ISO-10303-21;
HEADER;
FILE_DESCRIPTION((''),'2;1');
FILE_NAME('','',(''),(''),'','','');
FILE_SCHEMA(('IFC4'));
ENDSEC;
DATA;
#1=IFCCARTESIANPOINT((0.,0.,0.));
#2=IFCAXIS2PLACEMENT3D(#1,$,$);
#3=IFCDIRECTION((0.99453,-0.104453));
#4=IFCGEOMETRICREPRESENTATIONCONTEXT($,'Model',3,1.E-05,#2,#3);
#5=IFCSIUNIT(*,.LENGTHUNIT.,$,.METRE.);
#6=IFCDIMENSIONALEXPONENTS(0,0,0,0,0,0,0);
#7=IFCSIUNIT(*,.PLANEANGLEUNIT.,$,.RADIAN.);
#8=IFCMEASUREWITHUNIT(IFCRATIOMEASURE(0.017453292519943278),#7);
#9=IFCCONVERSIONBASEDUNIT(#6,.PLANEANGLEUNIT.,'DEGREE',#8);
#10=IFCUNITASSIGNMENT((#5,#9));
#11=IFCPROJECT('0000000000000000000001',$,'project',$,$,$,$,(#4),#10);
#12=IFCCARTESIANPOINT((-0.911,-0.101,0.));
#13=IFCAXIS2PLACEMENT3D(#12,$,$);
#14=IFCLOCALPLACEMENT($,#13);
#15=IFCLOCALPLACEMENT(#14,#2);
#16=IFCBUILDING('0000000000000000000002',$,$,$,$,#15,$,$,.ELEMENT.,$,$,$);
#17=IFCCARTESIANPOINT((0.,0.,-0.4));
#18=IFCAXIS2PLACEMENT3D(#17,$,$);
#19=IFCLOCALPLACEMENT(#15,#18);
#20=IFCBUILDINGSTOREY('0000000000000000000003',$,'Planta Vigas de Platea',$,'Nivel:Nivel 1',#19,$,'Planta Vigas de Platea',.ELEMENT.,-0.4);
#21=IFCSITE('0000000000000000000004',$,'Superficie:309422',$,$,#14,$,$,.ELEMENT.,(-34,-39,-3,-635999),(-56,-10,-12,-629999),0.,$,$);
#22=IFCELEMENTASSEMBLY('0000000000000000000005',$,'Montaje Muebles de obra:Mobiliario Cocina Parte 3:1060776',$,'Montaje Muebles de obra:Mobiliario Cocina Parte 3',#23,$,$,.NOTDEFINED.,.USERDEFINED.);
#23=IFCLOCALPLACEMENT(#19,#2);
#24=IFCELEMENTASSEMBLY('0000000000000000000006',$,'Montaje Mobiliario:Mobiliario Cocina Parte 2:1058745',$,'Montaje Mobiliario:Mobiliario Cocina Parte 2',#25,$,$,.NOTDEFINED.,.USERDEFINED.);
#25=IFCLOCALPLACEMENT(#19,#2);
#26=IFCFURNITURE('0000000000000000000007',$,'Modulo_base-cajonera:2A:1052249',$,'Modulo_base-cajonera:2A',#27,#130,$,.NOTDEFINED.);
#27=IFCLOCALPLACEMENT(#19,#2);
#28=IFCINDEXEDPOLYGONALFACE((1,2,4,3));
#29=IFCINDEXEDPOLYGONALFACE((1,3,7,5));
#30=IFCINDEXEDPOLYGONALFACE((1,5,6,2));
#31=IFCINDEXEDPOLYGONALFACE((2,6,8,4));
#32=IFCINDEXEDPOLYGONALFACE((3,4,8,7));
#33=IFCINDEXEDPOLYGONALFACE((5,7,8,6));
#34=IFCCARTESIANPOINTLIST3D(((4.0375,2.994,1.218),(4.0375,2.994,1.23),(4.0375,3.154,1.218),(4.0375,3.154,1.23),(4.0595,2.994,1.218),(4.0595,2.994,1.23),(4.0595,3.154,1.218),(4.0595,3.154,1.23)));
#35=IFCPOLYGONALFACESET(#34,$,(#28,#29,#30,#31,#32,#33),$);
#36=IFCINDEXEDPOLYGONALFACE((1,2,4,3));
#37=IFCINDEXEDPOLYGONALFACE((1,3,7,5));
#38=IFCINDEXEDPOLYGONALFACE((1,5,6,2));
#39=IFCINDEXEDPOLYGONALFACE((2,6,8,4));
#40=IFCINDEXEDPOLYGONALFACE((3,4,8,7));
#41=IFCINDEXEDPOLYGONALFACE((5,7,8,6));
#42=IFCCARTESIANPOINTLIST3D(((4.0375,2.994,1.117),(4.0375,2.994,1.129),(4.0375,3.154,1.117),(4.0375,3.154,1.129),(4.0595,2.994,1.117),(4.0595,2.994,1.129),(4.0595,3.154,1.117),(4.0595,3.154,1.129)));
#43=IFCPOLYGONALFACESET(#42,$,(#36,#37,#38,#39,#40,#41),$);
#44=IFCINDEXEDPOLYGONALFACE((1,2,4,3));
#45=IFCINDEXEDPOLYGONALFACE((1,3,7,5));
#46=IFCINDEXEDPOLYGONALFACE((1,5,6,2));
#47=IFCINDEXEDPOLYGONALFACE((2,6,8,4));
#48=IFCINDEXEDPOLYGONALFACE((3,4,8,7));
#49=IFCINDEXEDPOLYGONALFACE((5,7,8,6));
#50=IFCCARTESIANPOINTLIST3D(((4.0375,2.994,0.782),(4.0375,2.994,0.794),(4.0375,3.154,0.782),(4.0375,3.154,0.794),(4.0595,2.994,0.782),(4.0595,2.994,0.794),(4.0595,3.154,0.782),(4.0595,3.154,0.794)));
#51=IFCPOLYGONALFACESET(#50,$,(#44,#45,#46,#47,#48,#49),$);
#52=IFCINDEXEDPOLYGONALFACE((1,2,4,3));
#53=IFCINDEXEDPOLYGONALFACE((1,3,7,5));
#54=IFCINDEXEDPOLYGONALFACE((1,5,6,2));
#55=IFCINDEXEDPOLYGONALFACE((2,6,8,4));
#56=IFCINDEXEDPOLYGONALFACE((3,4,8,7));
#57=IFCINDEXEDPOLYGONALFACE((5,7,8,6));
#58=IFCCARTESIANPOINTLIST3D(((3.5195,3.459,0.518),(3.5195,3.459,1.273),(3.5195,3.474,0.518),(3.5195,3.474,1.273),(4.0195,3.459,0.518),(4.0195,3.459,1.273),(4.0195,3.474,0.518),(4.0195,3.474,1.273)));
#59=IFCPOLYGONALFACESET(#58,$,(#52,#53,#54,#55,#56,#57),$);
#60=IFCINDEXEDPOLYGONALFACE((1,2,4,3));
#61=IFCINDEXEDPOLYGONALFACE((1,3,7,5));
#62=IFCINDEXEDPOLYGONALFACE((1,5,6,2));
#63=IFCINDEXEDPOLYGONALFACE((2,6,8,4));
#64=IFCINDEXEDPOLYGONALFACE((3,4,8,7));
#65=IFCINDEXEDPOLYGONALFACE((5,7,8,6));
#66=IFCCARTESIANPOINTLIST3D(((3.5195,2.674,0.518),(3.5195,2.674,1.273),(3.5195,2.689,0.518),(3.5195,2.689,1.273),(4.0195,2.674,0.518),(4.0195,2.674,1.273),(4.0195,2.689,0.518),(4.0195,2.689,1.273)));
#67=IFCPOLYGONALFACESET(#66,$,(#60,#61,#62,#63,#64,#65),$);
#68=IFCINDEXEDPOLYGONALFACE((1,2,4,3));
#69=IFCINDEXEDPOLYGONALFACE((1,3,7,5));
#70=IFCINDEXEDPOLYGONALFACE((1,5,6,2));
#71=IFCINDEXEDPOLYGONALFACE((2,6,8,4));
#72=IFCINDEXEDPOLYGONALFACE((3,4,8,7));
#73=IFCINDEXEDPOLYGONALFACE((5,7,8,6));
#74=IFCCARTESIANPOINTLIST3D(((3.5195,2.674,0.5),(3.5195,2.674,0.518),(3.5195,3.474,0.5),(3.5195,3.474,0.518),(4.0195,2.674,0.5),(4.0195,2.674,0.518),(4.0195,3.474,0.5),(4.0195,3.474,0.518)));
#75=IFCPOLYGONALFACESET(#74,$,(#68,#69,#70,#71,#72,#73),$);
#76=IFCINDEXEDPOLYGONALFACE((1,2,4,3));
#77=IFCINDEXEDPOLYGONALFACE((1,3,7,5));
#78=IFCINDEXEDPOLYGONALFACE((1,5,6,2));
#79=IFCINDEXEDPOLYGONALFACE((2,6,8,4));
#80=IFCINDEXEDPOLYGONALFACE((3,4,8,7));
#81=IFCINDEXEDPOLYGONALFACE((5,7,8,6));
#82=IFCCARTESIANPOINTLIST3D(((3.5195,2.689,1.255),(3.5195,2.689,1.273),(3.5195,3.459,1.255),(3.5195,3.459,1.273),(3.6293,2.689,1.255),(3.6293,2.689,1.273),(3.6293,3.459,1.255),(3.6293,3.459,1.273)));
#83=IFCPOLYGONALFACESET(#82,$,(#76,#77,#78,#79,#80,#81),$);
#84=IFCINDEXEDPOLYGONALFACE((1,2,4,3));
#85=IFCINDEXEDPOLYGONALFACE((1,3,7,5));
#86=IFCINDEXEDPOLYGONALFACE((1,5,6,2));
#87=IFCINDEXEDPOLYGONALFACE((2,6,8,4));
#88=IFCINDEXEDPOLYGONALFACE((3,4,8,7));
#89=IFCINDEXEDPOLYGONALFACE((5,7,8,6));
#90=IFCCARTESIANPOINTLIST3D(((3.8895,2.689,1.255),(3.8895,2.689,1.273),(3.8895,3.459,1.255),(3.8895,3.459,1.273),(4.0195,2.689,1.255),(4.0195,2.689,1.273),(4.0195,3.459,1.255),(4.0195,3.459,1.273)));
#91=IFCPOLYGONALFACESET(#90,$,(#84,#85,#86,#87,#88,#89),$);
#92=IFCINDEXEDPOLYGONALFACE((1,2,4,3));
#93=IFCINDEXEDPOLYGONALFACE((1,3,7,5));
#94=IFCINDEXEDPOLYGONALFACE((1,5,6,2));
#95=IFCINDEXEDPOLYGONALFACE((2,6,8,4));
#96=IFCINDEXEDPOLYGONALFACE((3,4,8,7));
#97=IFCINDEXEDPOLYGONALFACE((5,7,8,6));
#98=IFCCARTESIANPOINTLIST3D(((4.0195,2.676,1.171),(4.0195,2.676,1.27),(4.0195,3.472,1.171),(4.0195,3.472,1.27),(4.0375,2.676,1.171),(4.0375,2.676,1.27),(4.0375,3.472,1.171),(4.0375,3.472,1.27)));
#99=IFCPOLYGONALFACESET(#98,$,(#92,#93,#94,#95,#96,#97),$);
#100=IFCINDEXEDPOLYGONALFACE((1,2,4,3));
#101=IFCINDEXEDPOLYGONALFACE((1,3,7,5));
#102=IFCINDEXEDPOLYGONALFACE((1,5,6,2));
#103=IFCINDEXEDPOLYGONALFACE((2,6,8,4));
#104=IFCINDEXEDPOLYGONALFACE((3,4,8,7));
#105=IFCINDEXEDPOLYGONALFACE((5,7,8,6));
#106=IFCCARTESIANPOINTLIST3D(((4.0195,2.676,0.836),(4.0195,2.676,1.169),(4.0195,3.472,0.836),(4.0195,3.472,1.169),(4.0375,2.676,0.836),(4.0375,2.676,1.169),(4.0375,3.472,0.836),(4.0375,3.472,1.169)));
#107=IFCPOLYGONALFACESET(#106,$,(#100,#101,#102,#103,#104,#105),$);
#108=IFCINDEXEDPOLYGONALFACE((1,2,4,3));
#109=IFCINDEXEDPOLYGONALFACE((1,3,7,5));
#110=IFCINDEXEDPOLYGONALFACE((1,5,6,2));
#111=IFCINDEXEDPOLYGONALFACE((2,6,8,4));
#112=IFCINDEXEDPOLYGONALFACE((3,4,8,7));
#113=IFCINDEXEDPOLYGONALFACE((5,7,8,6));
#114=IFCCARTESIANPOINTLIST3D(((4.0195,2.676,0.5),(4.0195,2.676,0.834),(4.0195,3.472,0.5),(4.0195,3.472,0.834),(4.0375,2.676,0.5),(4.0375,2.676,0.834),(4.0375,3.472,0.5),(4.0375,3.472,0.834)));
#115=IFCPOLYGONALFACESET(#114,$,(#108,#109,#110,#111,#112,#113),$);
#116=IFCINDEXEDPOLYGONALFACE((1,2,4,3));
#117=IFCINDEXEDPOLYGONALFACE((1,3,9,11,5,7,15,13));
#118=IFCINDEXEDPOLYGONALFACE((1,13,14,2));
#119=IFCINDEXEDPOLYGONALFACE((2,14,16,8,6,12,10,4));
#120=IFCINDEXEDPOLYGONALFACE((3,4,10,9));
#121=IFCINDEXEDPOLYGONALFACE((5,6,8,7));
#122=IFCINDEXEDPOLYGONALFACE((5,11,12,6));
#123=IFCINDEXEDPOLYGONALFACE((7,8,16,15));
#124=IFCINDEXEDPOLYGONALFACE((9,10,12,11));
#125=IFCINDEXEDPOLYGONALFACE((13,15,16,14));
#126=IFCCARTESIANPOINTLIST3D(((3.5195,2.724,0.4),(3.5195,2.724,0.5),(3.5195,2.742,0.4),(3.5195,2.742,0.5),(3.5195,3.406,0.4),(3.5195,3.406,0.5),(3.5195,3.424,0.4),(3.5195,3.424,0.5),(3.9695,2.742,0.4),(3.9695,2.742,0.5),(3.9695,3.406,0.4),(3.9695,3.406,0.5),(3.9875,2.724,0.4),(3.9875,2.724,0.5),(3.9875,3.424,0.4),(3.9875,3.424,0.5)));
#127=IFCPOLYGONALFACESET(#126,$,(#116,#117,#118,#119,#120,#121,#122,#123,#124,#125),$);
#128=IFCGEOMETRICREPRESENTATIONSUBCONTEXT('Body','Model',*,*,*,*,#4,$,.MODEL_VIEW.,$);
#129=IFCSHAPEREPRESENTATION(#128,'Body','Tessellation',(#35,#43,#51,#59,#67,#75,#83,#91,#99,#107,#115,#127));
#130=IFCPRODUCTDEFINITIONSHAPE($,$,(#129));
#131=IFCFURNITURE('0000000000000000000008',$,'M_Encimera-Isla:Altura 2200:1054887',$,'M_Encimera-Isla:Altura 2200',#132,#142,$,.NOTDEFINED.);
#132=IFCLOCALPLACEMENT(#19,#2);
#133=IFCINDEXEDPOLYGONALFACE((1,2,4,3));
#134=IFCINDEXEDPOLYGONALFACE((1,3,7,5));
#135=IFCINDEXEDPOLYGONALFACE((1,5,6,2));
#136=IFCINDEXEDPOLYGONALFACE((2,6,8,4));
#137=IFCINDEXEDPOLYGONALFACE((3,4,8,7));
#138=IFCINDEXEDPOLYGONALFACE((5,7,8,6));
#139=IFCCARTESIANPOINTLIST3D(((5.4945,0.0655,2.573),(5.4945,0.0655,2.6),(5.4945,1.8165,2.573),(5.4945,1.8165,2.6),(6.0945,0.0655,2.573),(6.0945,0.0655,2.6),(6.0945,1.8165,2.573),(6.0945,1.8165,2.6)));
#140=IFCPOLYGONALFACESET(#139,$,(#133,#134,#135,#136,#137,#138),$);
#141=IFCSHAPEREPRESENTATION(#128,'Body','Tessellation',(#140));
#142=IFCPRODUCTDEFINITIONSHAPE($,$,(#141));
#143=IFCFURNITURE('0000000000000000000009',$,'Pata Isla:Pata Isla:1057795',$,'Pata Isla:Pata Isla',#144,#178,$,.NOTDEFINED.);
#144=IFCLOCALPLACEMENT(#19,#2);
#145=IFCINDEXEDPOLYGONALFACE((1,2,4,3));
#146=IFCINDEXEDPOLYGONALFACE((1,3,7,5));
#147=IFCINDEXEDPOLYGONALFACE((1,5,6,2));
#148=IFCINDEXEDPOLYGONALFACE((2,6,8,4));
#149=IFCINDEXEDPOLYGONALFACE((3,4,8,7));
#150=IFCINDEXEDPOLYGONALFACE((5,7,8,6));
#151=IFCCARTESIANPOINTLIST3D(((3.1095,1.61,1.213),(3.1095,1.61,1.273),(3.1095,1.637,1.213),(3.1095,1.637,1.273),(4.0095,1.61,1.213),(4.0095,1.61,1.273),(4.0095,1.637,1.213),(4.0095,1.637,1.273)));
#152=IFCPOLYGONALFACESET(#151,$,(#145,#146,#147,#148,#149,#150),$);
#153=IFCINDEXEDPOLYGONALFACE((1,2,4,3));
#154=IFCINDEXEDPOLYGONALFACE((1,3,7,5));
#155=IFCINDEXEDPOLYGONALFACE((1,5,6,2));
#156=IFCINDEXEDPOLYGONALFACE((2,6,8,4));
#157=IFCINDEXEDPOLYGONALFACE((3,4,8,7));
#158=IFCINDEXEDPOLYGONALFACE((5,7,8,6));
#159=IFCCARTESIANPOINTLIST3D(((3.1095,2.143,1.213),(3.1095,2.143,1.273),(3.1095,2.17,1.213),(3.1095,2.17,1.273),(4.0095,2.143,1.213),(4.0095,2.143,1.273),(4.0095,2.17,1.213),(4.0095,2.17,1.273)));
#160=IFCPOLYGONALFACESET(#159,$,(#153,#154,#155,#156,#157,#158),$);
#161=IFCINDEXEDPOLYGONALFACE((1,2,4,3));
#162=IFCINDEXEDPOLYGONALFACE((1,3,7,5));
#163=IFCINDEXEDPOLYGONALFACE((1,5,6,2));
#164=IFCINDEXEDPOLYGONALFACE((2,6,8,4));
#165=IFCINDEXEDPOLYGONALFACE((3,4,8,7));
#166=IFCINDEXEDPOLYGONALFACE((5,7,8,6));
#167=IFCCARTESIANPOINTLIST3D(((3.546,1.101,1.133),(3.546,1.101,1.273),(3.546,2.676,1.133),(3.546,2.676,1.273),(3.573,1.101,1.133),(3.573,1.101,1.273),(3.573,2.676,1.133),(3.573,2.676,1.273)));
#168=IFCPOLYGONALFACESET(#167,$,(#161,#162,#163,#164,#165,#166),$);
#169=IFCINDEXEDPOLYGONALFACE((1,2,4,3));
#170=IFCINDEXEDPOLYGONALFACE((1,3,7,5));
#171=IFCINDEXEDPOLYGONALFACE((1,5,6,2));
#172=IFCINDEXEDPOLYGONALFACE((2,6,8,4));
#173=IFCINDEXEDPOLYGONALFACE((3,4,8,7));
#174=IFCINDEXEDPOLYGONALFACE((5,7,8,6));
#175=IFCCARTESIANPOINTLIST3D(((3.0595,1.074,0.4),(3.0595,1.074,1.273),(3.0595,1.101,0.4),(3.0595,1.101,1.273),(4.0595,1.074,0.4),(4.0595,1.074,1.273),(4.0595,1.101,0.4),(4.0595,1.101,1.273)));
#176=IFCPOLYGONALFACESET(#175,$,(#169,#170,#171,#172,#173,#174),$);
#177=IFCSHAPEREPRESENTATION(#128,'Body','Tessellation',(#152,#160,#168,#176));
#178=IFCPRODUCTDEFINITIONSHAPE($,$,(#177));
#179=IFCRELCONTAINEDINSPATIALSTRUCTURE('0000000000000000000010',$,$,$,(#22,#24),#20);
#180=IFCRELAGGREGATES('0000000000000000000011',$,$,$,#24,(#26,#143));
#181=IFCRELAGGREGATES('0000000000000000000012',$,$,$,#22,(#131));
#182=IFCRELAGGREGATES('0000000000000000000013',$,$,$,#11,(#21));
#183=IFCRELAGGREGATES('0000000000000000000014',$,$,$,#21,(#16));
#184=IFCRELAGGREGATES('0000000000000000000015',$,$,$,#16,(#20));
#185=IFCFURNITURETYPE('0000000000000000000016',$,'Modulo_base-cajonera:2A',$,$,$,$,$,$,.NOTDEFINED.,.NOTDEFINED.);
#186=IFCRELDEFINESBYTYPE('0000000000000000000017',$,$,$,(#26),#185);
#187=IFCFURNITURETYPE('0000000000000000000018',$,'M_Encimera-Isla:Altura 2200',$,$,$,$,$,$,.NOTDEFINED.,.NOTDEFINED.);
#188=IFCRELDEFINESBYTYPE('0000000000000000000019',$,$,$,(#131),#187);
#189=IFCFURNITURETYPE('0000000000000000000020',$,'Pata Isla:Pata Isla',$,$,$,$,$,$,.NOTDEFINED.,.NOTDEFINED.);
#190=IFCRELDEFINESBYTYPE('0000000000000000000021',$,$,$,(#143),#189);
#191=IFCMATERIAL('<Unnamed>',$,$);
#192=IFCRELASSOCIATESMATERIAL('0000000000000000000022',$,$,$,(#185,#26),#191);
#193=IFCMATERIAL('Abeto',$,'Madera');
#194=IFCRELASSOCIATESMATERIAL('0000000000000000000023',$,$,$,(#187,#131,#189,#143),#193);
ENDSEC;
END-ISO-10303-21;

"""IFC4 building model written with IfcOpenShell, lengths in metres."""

from ifc_helpers import new_model, entity, si_unit, converted_unit, direction, frame, frame_2d, origin, origin_2d_with_axis, place, context, subcontext, project, spatial, polyline, rectangle, outline, extrude, source, transform, mapped, material, type_object, type_shapes, element, aggregate, save


model = new_model("IFC4")

# Units and contexts
model_context = context("Model", 3, precision=1e-05, world=origin(), true_north=direction((0.99453, -0.104453)))
body_context = subcontext(model_context, "Body", "Model", "MODEL_VIEW")
ifc_project = project(units=[si_unit("LENGTHUNIT", "METRE"), converted_unit("PLANEANGLEUNIT", "DEGREE", entity("IfcRatioMeasure", 0.017453292519943278), si_unit("PLANEANGLEUNIT", "RADIAN"), dimensions=[0, 0, 0, 0, 0, 0, 0])], contexts=[model_context])

# Site, building, storey
site_placement = place(None, frame((-0.911, -0.101, 0.0)))
site = spatial("IfcSite", under=ifc_project, at=site_placement, Name="Superficie:309422", CompositionType="ELEMENT", RefLatitude=(-34, -39, -3, -635999), RefLongitude=(-56, -10, -12, -629999), RefElevation=0.0)
building_placement = place(site_placement, origin())
building = spatial("IfcBuilding", under=site, at=building_placement, CompositionType="ELEMENT")
storey_placement = place(building_placement, frame((0.0, 0.0, -0.4)))
storey = spatial("IfcBuildingStorey", under=building, at=storey_placement, Name="Planta Vigas de Platea", ObjectType="Nivel:Nivel 1", LongName="Planta Vigas de Platea", CompositionType="ELEMENT", Elevation=-0.4)

# Element assemblies
ifc_material_1 = material(Name="Abeto", Category="Madera")
ifc_material_2 = material(Name="<Unnamed>")
assembly_1_placement = place(storey_placement, origin())
assembly_1 = element("IfcElementAssembly", 1, at=assembly_1_placement, inside=storey, Name="Montaje Muebles de obra:Mobiliario Cocina Parte 3:1060776", ObjectType="Montaje Muebles de obra:Mobiliario Cocina Parte 3", AssemblyPlace="NOTDEFINED", PredefinedType="USERDEFINED")
assembly_2_placement = place(storey_placement, origin())
assembly_2 = element("IfcElementAssembly", 2, at=assembly_2_placement, inside=storey, Name="Montaje Mobiliario:Mobiliario Cocina Parte 2:1058745", ObjectType="Montaje Mobiliario:Mobiliario Cocina Parte 2", AssemblyPlace="NOTDEFINED", PredefinedType="USERDEFINED")

# Furniture
furniture_type_1 = type_object("IfcFurnitureType", Name="Modulo_base-cajonera:2A", AssemblyPlace="NOTDEFINED", PredefinedType="NOTDEFINED", material=ifc_material_2)
shared_shape_1 = source(origin(), body_context, "Body", "SweptSolid", [
    extrude(rectangle(XDim=0.16, YDim=0.022, at=frame_2d((0.0, 0.0), x_axis=(1.0, 0.0))), frame((0.529, 0.4, 0.818), z_axis=(0.0, 0.0, 1.0), x_axis=(0.0, 1.0, 0.0)), (0.0, 0.0, 1.0), 0.012),
    extrude(rectangle(XDim=0.16, YDim=0.022, at=frame_2d((0.0, 0.0), x_axis=(1.0, 0.0))), frame((0.529, 0.4, 0.717), z_axis=(0.0, 0.0, 1.0), x_axis=(0.0, 1.0, 0.0)), (0.0, 0.0, 1.0), 0.012),
    extrude(rectangle(XDim=0.16, YDim=0.022, at=frame_2d((0.0, 0.0), x_axis=(1.0, 0.0))), frame((0.529, 0.4, 0.382), z_axis=(0.0, 0.0, 1.0), x_axis=(0.0, 1.0, 0.0)), (0.0, 0.0, 1.0), 0.012),
    extrude(rectangle(XDim=0.5, YDim=0.015, at=origin_2d_with_axis()), frame((0.25, 0.7925, 0.118), z_axis=(0.0, 0.0, 1.0), x_axis=(-1.0, 0.0, 0.0)), (0.0, 0.0, 1.0), 0.755),
    extrude(rectangle(XDim=0.5, YDim=0.015, at=frame_2d((0.0, 0.0), x_axis=(1.0, 0.0))), frame((0.25, 0.0075, 0.118), z_axis=(0.0, 0.0, 1.0), x_axis=(-1.0, 0.0, 0.0)), (0.0, 0.0, 1.0), 0.755),
    extrude(rectangle(XDim=0.5, YDim=0.8, at=frame_2d((0.0, 0.0), x_axis=(1.0, 0.0))), frame((0.25, 0.4, 0.1), z_axis=(0.0, 0.0, 1.0), x_axis=(-1.0, 0.0, 0.0)), (0.0, 0.0, 1.0), 0.018),
    extrude(rectangle(XDim=0.1098, YDim=0.77, at=frame_2d((0.0, 0.0), x_axis=(1.0, 0.0))), frame((0.0549, 0.4, 0.855), z_axis=(0.0, 0.0, 1.0), x_axis=(-1.0, 0.0, 0.0)), (0.0, 0.0, 1.0), 0.018),
    extrude(rectangle(XDim=0.13, YDim=0.77, at=frame_2d((0.0, 0.0), x_axis=(1.0, 0.0))), frame((0.435, 0.4, 0.855)), (0.0, 0.0, 1.0), 0.018),
    extrude(rectangle(XDim=0.796, YDim=0.018, at=frame_2d((0.0, 0.0), x_axis=(1.0, 0.0))), frame((0.509, 0.4, 0.771), z_axis=(0.0, 0.0, 1.0), x_axis=(0.0, 1.0, 0.0)), (0.0, 0.0, 1.0), 0.099),
    extrude(rectangle(XDim=0.796, YDim=0.018, at=frame_2d((0.0, 0.0), x_axis=(1.0, 0.0))), frame((0.509, 0.4, 0.436), z_axis=(0.0, 0.0, 1.0), x_axis=(0.0, 1.0, 0.0)), (0.0, 0.0, 1.0), 0.333),
    extrude(rectangle(XDim=0.796, YDim=0.018, at=frame_2d((0.0, 0.0), x_axis=(1.0, 0.0))), frame((0.509, 0.4, 0.1), z_axis=(0.0, 0.0, 1.0), x_axis=(0.0, 1.0, 0.0)), (0.0, 0.0, 1.0), 0.334),
    extrude(outline(polyline([(-0.2385, -0.35), (0.2295, -0.35), (0.2295, -0.332), (-0.2205, -0.332), (-0.2205, 0.332), (0.2295, 0.332), (0.2295, 0.35), (-0.2385, 0.35), (-0.2385, -0.35)])), frame((0.2295, 0.4, 0.0), z_axis=(0.0, 0.0, 1.0), x_axis=(-1.0, 0.0, 0.0)), (0.0, 0.0, 1.0), 0.1),
])
type_shapes(furniture_type_1, [shared_shape_1])
furniture_1_placement = place(assembly_2_placement, frame((3.5195, 2.674, 0.4)))
furniture_1 = element("IfcFurniture", 3, at=furniture_1_placement, type_object=furniture_type_1, material=ifc_material_2, Name="Modulo_base-cajonera:2A:1052249", ObjectType="Modulo_base-cajonera:2A", PredefinedType="NOTDEFINED", context=body_context, shape_type="MappedRepresentation", body=[
    mapped(shared_shape_1, transform((0.0, 0.0, 0.0), scale=1.0)),
])
furniture_type_2 = type_object("IfcFurnitureType", Name="M_Encimera-Isla:Altura 2200", AssemblyPlace="NOTDEFINED", PredefinedType="NOTDEFINED", material=ifc_material_1)
shared_shape_2 = source(origin(), body_context, "Body", "SweptSolid", [
    extrude(rectangle(XDim=1.751, YDim=0.6, at=frame_2d((0.0, 0.0), x_axis=(1.0, 0.0))), frame((0.3, 0.8755, 0.0), z_axis=(0.0, 0.0, 1.0), x_axis=(0.0, 1.0, 0.0)), (0.0, 0.0, 1.0), 0.027),
])
type_shapes(furniture_type_2, [shared_shape_2])
furniture_2_placement = place(assembly_1_placement, frame((5.4945, 0.0655, 2.573)))
furniture_2 = element("IfcFurniture", 4, at=furniture_2_placement, type_object=furniture_type_2, material=ifc_material_1, Name="M_Encimera-Isla:Altura 2200:1054887", ObjectType="M_Encimera-Isla:Altura 2200", PredefinedType="NOTDEFINED", context=body_context, shape_type="MappedRepresentation", body=[
    mapped(shared_shape_2, transform((0.0, 0.0, 0.0), scale=1.0)),
])
furniture_type_3 = type_object("IfcFurnitureType", Name="Pata Isla:Pata Isla", AssemblyPlace="NOTDEFINED", PredefinedType="NOTDEFINED", material=ifc_material_1)
shared_shape_3 = source(origin(), body_context, "Body", "SweptSolid", [
    extrude(rectangle(XDim=0.9, YDim=0.027, at=frame_2d((0.0, 0.0), x_axis=(1.0, 0.0))), frame((0.5, 0.5495, 0.813)), (0.0, 0.0, 1.0), 0.06),
    extrude(rectangle(XDim=0.9, YDim=0.027, at=frame_2d((0.0, 0.0), x_axis=(1.0, 0.0))), frame((0.5, 1.0825, 0.813)), (0.0, 0.0, 1.0), 0.06),
    extrude(rectangle(XDim=0.027, YDim=1.575, at=frame_2d((0.0, 0.0), x_axis=(1.0, 0.0))), frame((0.5, 0.8145, 0.733), z_axis=(0.0, 0.0, 1.0), x_axis=(-1.0, 0.0, 0.0)), (0.0, 0.0, 1.0), 0.14),
    extrude(rectangle(XDim=0.027, YDim=1.0, at=frame_2d((0.0, 0.0), x_axis=(1.0, 0.0))), frame((0.5, 0.0135, 0.0), z_axis=(0.0, 0.0, 1.0), x_axis=(0.0, 1.0, 0.0)), (0.0, 0.0, 1.0), 0.873),
])
type_shapes(furniture_type_3, [shared_shape_3])
furniture_3_placement = place(assembly_2_placement, frame((3.0595, 1.074, 0.4)))
furniture_3 = element("IfcFurniture", 5, at=furniture_3_placement, type_object=furniture_type_3, material=ifc_material_1, Name="Pata Isla:Pata Isla:1057795", ObjectType="Pata Isla:Pata Isla", PredefinedType="NOTDEFINED", context=body_context, shape_type="MappedRepresentation", body=[
    mapped(shared_shape_3, transform((0.0, 0.0, 0.0), scale=1.0)),
])
aggregate(assembly_2, [furniture_1, furniture_3])
aggregate(assembly_1, [furniture_2])

save(model, "model.ifc")
